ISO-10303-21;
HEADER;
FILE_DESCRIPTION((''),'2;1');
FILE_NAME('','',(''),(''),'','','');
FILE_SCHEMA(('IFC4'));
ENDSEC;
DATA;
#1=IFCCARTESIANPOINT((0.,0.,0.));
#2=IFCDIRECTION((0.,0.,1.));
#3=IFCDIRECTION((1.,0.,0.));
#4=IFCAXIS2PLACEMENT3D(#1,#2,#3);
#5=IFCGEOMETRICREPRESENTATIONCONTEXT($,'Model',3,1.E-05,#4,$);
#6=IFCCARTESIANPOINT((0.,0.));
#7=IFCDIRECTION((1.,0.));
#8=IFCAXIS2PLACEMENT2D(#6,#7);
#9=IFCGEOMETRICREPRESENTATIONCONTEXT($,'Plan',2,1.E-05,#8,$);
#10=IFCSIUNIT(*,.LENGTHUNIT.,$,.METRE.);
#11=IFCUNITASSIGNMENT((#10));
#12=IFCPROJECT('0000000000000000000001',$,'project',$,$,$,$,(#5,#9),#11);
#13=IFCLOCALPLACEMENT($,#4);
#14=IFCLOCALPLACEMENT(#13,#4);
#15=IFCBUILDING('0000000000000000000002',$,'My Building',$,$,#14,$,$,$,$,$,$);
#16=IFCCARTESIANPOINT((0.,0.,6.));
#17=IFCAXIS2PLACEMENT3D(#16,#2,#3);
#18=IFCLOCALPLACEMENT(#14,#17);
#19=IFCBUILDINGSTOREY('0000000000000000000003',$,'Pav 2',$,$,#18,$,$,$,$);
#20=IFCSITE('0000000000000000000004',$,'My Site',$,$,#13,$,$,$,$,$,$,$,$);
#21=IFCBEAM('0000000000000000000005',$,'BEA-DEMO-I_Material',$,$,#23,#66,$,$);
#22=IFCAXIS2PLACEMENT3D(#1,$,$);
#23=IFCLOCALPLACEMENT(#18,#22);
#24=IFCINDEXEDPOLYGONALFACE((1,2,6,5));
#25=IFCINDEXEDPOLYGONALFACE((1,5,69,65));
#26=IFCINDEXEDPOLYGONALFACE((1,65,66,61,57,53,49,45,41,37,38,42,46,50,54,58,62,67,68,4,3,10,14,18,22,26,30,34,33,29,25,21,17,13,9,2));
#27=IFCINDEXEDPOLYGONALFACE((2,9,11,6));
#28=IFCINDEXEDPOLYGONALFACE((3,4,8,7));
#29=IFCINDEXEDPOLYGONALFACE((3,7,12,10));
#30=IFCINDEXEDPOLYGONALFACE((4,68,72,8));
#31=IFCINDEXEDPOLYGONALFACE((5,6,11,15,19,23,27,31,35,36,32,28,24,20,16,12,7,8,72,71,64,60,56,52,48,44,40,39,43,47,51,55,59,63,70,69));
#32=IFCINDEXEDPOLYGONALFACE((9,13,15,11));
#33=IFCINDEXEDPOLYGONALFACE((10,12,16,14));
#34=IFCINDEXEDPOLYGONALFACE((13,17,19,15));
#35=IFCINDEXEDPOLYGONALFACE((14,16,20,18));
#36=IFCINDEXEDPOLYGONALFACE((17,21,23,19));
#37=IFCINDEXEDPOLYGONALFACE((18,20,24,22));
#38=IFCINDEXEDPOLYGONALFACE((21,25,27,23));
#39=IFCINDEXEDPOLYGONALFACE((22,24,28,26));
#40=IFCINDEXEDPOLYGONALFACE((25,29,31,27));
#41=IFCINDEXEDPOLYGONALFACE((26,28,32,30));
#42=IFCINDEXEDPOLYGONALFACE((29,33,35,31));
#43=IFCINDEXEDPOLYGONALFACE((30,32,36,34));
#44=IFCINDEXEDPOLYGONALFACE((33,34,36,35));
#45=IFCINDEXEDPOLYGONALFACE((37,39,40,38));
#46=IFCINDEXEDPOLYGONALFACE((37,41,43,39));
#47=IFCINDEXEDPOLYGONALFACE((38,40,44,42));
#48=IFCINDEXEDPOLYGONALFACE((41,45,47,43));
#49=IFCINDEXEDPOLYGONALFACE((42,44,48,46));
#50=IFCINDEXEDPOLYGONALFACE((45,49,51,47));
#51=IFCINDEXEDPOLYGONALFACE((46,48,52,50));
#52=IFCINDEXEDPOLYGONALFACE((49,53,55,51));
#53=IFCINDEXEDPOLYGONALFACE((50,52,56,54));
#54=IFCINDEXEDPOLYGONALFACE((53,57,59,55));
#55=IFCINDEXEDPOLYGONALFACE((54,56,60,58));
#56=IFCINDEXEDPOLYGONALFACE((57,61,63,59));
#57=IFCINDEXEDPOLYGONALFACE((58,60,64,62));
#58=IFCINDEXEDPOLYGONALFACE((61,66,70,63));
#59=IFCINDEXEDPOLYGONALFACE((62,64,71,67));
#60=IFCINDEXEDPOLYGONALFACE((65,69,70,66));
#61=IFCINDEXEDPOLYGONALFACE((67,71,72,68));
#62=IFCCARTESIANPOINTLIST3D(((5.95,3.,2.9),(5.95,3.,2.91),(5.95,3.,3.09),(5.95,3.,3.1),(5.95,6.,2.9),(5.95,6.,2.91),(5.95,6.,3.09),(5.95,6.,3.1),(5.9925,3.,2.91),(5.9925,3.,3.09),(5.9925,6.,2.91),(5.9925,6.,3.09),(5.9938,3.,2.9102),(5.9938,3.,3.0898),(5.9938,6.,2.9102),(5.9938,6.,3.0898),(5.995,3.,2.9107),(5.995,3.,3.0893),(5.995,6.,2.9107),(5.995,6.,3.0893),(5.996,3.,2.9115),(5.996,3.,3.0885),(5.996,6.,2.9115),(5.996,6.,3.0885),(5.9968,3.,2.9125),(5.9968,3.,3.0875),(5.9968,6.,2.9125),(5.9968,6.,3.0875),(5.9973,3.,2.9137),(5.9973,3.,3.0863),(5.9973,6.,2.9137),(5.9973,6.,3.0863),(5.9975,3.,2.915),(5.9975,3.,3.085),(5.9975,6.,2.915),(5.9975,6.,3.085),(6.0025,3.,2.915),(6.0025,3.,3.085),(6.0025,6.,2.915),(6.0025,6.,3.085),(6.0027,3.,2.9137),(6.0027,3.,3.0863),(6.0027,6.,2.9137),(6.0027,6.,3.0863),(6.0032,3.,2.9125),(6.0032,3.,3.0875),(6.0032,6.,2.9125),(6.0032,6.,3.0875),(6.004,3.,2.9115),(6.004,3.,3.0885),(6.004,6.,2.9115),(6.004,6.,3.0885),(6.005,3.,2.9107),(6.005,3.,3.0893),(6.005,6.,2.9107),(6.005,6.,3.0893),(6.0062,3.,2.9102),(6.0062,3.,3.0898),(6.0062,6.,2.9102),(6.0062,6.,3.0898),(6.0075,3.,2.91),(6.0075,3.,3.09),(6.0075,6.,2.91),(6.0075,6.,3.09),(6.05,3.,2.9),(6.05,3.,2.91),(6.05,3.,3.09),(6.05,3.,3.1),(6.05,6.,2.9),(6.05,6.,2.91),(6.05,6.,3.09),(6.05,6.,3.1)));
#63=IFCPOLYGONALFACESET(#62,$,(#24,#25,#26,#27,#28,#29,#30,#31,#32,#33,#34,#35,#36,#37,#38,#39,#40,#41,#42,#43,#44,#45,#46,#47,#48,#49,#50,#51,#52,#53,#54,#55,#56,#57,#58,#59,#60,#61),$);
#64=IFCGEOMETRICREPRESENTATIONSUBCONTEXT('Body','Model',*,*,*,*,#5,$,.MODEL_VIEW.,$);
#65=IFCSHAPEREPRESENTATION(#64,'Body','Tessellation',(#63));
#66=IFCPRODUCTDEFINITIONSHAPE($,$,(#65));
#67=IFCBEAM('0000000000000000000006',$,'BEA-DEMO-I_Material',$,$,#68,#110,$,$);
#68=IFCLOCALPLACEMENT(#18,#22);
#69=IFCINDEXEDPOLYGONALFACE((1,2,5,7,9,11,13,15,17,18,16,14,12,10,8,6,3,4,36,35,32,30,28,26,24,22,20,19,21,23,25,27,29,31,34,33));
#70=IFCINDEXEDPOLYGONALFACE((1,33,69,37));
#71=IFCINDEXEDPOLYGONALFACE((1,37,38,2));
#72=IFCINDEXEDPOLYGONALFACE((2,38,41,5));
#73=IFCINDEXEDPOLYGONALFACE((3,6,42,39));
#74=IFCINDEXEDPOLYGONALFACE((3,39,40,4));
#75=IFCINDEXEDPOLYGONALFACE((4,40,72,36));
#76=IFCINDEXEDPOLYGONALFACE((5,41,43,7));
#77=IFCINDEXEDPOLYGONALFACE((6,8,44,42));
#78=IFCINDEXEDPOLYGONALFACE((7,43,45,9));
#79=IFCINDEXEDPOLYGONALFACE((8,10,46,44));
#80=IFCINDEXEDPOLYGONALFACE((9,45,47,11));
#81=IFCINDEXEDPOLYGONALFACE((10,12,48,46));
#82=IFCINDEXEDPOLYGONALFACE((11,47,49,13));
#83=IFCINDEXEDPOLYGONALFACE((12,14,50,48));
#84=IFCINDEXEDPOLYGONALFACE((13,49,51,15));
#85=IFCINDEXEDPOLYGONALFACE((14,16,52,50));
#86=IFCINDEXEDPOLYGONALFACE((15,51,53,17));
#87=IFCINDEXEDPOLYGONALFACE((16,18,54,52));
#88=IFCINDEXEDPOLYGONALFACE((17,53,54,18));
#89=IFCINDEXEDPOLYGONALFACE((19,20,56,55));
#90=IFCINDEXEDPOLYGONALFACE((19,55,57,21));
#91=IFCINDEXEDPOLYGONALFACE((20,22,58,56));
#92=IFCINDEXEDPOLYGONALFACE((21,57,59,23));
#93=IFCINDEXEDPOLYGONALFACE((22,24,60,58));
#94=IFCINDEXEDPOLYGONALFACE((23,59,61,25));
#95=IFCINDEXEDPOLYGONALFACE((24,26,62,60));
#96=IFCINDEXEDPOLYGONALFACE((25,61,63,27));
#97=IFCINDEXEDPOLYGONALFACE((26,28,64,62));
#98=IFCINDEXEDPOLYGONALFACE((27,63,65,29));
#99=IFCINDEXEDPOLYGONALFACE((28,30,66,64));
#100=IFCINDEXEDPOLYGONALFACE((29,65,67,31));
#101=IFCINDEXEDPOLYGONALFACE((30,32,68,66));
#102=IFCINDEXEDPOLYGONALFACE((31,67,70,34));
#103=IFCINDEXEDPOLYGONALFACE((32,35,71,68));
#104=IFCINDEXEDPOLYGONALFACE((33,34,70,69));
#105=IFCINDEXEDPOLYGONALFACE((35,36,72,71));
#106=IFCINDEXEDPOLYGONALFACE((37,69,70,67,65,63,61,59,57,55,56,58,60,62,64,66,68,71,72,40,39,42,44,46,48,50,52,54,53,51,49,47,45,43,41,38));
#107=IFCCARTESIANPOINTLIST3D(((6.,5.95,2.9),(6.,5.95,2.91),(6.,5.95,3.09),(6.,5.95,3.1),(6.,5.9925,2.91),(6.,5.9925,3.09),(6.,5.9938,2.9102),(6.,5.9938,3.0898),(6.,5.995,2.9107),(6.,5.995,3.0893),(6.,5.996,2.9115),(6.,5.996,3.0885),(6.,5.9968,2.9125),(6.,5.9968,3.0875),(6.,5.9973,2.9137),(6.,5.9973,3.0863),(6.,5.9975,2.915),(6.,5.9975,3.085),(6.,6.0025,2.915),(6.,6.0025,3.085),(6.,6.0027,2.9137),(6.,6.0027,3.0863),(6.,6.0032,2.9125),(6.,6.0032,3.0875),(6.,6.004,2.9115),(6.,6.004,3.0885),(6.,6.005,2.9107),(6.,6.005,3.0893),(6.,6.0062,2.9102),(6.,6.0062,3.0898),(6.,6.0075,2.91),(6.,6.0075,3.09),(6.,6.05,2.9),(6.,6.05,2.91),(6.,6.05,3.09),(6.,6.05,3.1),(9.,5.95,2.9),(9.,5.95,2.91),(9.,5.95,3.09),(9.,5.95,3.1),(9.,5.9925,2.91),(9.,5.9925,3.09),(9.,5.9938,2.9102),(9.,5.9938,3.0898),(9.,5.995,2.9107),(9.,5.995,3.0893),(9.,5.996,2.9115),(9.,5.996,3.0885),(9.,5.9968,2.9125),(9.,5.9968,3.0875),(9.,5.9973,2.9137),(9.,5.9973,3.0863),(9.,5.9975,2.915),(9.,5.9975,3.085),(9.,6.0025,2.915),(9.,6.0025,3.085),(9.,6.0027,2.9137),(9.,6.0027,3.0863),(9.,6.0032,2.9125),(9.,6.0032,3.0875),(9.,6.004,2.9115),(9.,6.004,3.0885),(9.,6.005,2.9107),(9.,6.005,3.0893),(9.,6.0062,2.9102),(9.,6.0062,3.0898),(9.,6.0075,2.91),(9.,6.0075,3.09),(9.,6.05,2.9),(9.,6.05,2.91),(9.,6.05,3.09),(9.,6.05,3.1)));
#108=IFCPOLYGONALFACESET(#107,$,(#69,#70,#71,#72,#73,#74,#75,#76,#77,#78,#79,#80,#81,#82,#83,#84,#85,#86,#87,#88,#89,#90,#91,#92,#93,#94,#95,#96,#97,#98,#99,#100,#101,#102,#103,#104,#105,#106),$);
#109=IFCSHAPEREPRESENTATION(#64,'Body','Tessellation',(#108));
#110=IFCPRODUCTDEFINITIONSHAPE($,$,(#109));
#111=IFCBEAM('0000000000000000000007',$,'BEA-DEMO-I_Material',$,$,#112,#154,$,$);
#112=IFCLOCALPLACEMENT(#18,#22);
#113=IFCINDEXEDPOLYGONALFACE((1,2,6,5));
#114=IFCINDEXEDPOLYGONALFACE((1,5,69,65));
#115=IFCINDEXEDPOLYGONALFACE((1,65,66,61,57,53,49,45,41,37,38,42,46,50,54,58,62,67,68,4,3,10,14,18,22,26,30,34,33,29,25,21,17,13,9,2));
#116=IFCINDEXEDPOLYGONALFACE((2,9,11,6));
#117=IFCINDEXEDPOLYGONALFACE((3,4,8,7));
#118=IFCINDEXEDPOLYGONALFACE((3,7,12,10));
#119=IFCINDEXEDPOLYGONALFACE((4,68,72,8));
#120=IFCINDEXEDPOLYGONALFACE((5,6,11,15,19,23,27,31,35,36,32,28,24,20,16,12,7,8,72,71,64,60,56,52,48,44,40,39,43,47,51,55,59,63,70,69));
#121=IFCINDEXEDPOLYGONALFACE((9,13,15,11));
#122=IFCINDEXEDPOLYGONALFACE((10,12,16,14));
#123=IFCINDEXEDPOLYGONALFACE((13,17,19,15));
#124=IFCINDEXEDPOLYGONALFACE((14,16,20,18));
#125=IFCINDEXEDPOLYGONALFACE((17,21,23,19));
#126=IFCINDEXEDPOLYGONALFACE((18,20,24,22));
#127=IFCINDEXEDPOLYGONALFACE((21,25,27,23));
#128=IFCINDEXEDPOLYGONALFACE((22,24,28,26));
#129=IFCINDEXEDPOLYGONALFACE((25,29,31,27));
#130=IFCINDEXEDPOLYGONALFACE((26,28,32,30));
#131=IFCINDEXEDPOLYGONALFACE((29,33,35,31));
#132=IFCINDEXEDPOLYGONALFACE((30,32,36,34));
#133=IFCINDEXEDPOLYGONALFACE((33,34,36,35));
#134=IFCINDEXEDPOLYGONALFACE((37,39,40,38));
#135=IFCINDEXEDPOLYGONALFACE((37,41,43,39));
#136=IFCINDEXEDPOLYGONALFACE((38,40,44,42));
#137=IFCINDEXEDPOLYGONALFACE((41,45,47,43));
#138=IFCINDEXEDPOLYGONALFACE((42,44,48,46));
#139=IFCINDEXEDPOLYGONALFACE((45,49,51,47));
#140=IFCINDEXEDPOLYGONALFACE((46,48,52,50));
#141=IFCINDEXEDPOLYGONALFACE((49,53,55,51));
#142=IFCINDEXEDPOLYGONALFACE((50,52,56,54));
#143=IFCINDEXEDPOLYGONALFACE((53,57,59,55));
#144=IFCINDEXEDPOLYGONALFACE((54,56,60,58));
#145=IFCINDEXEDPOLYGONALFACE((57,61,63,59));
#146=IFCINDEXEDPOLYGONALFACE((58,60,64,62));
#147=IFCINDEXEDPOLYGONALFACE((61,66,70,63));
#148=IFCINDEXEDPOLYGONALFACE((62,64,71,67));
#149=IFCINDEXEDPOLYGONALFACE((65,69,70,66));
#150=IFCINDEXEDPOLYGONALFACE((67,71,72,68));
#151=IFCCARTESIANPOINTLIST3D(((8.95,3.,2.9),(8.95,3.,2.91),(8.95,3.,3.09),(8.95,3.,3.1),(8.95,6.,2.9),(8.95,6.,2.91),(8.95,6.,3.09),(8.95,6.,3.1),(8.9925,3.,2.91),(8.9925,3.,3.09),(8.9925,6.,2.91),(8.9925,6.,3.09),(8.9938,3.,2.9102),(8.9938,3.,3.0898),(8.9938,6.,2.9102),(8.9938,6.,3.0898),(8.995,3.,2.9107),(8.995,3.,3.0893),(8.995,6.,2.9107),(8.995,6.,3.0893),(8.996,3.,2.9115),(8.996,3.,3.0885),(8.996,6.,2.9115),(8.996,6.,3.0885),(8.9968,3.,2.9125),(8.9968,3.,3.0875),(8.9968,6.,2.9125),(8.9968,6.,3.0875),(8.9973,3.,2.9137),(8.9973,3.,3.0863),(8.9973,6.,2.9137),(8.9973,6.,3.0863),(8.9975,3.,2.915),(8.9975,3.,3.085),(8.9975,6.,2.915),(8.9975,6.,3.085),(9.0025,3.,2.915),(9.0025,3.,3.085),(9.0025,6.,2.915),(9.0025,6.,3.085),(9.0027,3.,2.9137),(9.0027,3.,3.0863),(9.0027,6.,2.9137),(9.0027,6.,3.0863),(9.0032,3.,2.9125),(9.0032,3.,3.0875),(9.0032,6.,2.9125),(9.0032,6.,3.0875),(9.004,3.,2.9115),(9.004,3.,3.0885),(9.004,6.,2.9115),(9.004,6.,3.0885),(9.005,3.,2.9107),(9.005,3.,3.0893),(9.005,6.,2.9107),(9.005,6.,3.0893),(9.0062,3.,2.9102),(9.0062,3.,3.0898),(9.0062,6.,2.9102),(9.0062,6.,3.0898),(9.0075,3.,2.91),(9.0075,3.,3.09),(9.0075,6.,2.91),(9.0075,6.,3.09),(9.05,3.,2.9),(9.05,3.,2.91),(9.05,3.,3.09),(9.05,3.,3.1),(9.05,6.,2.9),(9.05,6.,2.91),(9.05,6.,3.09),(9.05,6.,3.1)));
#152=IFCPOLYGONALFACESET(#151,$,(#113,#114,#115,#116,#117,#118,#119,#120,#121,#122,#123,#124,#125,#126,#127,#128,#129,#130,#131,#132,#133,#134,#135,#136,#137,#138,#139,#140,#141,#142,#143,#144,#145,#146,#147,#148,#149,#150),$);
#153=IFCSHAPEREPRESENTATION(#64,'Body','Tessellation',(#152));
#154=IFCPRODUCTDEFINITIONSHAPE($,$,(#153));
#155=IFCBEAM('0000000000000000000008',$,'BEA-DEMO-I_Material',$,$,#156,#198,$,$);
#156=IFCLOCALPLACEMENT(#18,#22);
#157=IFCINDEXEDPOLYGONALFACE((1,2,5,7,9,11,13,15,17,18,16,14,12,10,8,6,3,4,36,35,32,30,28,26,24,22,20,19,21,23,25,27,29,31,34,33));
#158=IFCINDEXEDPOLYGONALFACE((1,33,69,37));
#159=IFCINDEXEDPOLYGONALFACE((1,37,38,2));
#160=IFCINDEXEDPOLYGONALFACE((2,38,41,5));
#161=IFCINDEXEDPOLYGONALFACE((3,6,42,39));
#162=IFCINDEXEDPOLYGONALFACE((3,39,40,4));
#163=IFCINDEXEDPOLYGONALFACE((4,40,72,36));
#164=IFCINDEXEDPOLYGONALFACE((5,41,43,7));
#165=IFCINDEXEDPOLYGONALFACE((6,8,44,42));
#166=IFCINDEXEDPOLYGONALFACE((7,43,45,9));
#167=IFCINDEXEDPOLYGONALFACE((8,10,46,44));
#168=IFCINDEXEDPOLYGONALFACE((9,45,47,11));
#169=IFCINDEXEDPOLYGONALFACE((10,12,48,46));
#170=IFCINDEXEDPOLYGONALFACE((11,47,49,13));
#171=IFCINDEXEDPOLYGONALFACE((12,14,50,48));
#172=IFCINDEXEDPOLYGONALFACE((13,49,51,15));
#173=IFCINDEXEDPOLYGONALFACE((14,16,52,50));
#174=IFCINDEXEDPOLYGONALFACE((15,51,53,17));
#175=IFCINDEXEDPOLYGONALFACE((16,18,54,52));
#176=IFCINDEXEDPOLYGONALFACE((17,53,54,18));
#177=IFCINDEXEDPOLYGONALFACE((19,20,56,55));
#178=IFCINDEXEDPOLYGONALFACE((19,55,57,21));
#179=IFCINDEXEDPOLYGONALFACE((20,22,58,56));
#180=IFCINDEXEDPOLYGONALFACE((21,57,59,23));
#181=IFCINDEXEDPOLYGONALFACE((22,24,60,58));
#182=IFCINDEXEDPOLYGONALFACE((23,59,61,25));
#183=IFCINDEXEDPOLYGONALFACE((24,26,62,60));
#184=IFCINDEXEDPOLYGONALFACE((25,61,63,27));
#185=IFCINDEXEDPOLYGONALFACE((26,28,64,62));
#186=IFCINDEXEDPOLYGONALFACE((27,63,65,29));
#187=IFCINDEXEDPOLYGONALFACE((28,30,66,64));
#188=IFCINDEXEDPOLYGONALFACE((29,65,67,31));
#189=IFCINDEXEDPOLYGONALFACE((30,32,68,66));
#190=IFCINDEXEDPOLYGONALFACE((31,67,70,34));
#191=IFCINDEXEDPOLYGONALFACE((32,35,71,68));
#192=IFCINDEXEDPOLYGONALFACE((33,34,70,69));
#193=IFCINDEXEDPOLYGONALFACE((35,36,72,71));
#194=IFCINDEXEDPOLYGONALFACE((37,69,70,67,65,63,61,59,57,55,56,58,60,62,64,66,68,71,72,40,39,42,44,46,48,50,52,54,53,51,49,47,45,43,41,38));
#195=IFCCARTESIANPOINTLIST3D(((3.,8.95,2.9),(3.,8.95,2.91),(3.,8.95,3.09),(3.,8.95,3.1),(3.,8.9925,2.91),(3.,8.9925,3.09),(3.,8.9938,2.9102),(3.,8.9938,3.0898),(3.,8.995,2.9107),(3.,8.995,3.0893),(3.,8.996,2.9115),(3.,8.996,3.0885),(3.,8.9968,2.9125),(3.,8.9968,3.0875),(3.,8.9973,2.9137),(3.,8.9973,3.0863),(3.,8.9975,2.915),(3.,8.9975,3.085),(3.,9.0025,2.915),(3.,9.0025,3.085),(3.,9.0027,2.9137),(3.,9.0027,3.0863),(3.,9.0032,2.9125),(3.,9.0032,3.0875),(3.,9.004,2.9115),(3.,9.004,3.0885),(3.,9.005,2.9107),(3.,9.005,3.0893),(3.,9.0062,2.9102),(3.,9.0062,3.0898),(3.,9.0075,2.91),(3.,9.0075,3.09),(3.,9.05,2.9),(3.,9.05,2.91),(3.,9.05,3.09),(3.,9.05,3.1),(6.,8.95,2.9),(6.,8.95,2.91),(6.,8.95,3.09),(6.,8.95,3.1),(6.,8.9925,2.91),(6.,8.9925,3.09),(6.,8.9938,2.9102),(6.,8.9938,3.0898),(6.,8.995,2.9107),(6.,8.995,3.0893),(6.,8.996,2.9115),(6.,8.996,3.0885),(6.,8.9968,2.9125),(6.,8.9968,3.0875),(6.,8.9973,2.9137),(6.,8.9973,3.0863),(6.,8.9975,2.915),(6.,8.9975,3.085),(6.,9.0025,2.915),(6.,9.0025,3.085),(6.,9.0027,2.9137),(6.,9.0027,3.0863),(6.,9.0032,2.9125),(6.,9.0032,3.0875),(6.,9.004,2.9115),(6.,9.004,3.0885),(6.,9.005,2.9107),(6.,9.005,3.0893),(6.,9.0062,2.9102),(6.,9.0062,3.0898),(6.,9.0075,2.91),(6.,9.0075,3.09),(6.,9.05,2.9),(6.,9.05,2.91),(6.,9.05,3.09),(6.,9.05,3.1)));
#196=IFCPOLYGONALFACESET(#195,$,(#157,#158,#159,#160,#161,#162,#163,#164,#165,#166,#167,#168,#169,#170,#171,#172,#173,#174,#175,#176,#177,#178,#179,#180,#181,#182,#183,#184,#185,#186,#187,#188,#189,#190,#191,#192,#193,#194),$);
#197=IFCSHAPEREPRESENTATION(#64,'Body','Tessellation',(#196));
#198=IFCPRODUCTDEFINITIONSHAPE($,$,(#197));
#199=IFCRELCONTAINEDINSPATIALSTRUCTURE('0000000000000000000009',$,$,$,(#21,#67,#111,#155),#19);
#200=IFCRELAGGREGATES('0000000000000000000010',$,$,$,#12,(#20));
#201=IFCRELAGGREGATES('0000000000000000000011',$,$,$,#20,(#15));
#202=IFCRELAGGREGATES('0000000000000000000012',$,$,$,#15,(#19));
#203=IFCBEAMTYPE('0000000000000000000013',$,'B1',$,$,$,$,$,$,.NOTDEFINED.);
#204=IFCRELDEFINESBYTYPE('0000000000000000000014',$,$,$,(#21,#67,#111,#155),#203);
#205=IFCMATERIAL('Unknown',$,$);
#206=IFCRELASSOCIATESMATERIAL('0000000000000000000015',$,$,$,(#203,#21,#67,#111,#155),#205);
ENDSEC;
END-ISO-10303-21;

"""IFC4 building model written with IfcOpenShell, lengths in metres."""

from ifc_helpers import new_model, si_unit, frame, origin, origin_with_axes, origin_2d_with_axis, place, context, subcontext, project, spatial, i_section, extrude, material, material_profile, profile_set, profile_usage, type_object, element, save


model = new_model("IFC4")

# Units and contexts
model_context = context("Model", 3, precision=1e-05, world=origin_with_axes())
plan_context = context("Plan", 2, precision=1e-05, world=origin_2d_with_axis())
body_context = subcontext(model_context, "Body", "Model", "MODEL_VIEW")
ifc_project = project(units=[si_unit("LENGTHUNIT", "METRE")], contexts=[model_context, plan_context])

# Site, building, storey
site_placement = place(None, origin_with_axes())
site = spatial("IfcSite", under=ifc_project, at=site_placement, Name="My Site")
building_placement = place(site_placement, origin_with_axes())
building = spatial("IfcBuilding", under=site, at=building_placement, Name="My Building")
storey_placement = place(building_placement, frame((0.0, 0.0, 6.0), z_axis=(0.0, 0.0, 1.0), x_axis=(1.0, 0.0, 0.0)))
storey = spatial("IfcBuildingStorey", under=building, at=storey_placement, Name="Pav 2")

# Beams
ifc_material = material(Name="Unknown")
ifc_material_profile = material_profile(ifc_material, i_section(OverallWidth=0.1, OverallDepth=0.2, WebThickness=0.005, FlangeThickness=0.01, FilletRadius=0.005))
ifc_profile_set = profile_set([ifc_material_profile])
beam_type = type_object("IfcBeamType", Name="B1", PredefinedType="NOTDEFINED", material=ifc_profile_set)
ifc_profile_usage_1 = profile_usage(ifc_profile_set, cardinal=5)
beam_1_placement = place(storey_placement, frame((6.0, 6.0, 3.0), z_axis=(0.0, -1.0, 0.0), x_axis=(1.0, 0.0, 0.0)))
element("IfcBeam", 1, at=beam_1_placement, inside=storey, type_object=beam_type, material=ifc_profile_usage_1, Name="BEA-DEMO-I_Material", context=body_context, shape_type="SweptSolid", body=[
    extrude(i_section(OverallWidth=0.1, OverallDepth=0.2, WebThickness=0.005, FlangeThickness=0.01, FilletRadius=0.005), origin(), (0.0, 0.0, 1.0), 3.0),
])
ifc_profile_usage_2 = profile_usage(ifc_profile_set, cardinal=5)
beam_2_placement = place(storey_placement, frame((6.0, 6.0, 3.0), z_axis=(1.0, 0.0, 0.0), x_axis=(0.0, 1.0, 0.0)))
element("IfcBeam", 2, at=beam_2_placement, inside=storey, type_object=beam_type, material=ifc_profile_usage_2, Name="BEA-DEMO-I_Material", context=body_context, shape_type="SweptSolid", body=[
    extrude(i_section(OverallWidth=0.1, OverallDepth=0.2, WebThickness=0.005, FlangeThickness=0.01, FilletRadius=0.005), origin(), (0.0, 0.0, 1.0), 3.0),
])
ifc_profile_usage_3 = profile_usage(ifc_profile_set, cardinal=5)
beam_3_placement = place(storey_placement, frame((9.0, 6.0, 3.0), z_axis=(0.0, -1.0, 0.0), x_axis=(1.0, 0.0, 0.0)))
element("IfcBeam", 3, at=beam_3_placement, inside=storey, type_object=beam_type, material=ifc_profile_usage_3, Name="BEA-DEMO-I_Material", context=body_context, shape_type="SweptSolid", body=[
    extrude(i_section(OverallWidth=0.1, OverallDepth=0.2, WebThickness=0.005, FlangeThickness=0.01, FilletRadius=0.005), origin(), (0.0, 0.0, 1.0), 3.0),
])
ifc_profile_usage_4 = profile_usage(ifc_profile_set, cardinal=5)
beam_4_placement = place(storey_placement, frame((3.0, 9.0, 3.0), z_axis=(1.0, 0.0, 0.0), x_axis=(0.0, 1.0, 0.0)))
element("IfcBeam", 4, at=beam_4_placement, inside=storey, type_object=beam_type, material=ifc_profile_usage_4, Name="BEA-DEMO-I_Material", context=body_context, shape_type="SweptSolid", body=[
    extrude(i_section(OverallWidth=0.1, OverallDepth=0.2, WebThickness=0.005, FlangeThickness=0.01, FilletRadius=0.005), origin(), (0.0, 0.0, 1.0), 3.0),
])

save(model, "model.ifc")
